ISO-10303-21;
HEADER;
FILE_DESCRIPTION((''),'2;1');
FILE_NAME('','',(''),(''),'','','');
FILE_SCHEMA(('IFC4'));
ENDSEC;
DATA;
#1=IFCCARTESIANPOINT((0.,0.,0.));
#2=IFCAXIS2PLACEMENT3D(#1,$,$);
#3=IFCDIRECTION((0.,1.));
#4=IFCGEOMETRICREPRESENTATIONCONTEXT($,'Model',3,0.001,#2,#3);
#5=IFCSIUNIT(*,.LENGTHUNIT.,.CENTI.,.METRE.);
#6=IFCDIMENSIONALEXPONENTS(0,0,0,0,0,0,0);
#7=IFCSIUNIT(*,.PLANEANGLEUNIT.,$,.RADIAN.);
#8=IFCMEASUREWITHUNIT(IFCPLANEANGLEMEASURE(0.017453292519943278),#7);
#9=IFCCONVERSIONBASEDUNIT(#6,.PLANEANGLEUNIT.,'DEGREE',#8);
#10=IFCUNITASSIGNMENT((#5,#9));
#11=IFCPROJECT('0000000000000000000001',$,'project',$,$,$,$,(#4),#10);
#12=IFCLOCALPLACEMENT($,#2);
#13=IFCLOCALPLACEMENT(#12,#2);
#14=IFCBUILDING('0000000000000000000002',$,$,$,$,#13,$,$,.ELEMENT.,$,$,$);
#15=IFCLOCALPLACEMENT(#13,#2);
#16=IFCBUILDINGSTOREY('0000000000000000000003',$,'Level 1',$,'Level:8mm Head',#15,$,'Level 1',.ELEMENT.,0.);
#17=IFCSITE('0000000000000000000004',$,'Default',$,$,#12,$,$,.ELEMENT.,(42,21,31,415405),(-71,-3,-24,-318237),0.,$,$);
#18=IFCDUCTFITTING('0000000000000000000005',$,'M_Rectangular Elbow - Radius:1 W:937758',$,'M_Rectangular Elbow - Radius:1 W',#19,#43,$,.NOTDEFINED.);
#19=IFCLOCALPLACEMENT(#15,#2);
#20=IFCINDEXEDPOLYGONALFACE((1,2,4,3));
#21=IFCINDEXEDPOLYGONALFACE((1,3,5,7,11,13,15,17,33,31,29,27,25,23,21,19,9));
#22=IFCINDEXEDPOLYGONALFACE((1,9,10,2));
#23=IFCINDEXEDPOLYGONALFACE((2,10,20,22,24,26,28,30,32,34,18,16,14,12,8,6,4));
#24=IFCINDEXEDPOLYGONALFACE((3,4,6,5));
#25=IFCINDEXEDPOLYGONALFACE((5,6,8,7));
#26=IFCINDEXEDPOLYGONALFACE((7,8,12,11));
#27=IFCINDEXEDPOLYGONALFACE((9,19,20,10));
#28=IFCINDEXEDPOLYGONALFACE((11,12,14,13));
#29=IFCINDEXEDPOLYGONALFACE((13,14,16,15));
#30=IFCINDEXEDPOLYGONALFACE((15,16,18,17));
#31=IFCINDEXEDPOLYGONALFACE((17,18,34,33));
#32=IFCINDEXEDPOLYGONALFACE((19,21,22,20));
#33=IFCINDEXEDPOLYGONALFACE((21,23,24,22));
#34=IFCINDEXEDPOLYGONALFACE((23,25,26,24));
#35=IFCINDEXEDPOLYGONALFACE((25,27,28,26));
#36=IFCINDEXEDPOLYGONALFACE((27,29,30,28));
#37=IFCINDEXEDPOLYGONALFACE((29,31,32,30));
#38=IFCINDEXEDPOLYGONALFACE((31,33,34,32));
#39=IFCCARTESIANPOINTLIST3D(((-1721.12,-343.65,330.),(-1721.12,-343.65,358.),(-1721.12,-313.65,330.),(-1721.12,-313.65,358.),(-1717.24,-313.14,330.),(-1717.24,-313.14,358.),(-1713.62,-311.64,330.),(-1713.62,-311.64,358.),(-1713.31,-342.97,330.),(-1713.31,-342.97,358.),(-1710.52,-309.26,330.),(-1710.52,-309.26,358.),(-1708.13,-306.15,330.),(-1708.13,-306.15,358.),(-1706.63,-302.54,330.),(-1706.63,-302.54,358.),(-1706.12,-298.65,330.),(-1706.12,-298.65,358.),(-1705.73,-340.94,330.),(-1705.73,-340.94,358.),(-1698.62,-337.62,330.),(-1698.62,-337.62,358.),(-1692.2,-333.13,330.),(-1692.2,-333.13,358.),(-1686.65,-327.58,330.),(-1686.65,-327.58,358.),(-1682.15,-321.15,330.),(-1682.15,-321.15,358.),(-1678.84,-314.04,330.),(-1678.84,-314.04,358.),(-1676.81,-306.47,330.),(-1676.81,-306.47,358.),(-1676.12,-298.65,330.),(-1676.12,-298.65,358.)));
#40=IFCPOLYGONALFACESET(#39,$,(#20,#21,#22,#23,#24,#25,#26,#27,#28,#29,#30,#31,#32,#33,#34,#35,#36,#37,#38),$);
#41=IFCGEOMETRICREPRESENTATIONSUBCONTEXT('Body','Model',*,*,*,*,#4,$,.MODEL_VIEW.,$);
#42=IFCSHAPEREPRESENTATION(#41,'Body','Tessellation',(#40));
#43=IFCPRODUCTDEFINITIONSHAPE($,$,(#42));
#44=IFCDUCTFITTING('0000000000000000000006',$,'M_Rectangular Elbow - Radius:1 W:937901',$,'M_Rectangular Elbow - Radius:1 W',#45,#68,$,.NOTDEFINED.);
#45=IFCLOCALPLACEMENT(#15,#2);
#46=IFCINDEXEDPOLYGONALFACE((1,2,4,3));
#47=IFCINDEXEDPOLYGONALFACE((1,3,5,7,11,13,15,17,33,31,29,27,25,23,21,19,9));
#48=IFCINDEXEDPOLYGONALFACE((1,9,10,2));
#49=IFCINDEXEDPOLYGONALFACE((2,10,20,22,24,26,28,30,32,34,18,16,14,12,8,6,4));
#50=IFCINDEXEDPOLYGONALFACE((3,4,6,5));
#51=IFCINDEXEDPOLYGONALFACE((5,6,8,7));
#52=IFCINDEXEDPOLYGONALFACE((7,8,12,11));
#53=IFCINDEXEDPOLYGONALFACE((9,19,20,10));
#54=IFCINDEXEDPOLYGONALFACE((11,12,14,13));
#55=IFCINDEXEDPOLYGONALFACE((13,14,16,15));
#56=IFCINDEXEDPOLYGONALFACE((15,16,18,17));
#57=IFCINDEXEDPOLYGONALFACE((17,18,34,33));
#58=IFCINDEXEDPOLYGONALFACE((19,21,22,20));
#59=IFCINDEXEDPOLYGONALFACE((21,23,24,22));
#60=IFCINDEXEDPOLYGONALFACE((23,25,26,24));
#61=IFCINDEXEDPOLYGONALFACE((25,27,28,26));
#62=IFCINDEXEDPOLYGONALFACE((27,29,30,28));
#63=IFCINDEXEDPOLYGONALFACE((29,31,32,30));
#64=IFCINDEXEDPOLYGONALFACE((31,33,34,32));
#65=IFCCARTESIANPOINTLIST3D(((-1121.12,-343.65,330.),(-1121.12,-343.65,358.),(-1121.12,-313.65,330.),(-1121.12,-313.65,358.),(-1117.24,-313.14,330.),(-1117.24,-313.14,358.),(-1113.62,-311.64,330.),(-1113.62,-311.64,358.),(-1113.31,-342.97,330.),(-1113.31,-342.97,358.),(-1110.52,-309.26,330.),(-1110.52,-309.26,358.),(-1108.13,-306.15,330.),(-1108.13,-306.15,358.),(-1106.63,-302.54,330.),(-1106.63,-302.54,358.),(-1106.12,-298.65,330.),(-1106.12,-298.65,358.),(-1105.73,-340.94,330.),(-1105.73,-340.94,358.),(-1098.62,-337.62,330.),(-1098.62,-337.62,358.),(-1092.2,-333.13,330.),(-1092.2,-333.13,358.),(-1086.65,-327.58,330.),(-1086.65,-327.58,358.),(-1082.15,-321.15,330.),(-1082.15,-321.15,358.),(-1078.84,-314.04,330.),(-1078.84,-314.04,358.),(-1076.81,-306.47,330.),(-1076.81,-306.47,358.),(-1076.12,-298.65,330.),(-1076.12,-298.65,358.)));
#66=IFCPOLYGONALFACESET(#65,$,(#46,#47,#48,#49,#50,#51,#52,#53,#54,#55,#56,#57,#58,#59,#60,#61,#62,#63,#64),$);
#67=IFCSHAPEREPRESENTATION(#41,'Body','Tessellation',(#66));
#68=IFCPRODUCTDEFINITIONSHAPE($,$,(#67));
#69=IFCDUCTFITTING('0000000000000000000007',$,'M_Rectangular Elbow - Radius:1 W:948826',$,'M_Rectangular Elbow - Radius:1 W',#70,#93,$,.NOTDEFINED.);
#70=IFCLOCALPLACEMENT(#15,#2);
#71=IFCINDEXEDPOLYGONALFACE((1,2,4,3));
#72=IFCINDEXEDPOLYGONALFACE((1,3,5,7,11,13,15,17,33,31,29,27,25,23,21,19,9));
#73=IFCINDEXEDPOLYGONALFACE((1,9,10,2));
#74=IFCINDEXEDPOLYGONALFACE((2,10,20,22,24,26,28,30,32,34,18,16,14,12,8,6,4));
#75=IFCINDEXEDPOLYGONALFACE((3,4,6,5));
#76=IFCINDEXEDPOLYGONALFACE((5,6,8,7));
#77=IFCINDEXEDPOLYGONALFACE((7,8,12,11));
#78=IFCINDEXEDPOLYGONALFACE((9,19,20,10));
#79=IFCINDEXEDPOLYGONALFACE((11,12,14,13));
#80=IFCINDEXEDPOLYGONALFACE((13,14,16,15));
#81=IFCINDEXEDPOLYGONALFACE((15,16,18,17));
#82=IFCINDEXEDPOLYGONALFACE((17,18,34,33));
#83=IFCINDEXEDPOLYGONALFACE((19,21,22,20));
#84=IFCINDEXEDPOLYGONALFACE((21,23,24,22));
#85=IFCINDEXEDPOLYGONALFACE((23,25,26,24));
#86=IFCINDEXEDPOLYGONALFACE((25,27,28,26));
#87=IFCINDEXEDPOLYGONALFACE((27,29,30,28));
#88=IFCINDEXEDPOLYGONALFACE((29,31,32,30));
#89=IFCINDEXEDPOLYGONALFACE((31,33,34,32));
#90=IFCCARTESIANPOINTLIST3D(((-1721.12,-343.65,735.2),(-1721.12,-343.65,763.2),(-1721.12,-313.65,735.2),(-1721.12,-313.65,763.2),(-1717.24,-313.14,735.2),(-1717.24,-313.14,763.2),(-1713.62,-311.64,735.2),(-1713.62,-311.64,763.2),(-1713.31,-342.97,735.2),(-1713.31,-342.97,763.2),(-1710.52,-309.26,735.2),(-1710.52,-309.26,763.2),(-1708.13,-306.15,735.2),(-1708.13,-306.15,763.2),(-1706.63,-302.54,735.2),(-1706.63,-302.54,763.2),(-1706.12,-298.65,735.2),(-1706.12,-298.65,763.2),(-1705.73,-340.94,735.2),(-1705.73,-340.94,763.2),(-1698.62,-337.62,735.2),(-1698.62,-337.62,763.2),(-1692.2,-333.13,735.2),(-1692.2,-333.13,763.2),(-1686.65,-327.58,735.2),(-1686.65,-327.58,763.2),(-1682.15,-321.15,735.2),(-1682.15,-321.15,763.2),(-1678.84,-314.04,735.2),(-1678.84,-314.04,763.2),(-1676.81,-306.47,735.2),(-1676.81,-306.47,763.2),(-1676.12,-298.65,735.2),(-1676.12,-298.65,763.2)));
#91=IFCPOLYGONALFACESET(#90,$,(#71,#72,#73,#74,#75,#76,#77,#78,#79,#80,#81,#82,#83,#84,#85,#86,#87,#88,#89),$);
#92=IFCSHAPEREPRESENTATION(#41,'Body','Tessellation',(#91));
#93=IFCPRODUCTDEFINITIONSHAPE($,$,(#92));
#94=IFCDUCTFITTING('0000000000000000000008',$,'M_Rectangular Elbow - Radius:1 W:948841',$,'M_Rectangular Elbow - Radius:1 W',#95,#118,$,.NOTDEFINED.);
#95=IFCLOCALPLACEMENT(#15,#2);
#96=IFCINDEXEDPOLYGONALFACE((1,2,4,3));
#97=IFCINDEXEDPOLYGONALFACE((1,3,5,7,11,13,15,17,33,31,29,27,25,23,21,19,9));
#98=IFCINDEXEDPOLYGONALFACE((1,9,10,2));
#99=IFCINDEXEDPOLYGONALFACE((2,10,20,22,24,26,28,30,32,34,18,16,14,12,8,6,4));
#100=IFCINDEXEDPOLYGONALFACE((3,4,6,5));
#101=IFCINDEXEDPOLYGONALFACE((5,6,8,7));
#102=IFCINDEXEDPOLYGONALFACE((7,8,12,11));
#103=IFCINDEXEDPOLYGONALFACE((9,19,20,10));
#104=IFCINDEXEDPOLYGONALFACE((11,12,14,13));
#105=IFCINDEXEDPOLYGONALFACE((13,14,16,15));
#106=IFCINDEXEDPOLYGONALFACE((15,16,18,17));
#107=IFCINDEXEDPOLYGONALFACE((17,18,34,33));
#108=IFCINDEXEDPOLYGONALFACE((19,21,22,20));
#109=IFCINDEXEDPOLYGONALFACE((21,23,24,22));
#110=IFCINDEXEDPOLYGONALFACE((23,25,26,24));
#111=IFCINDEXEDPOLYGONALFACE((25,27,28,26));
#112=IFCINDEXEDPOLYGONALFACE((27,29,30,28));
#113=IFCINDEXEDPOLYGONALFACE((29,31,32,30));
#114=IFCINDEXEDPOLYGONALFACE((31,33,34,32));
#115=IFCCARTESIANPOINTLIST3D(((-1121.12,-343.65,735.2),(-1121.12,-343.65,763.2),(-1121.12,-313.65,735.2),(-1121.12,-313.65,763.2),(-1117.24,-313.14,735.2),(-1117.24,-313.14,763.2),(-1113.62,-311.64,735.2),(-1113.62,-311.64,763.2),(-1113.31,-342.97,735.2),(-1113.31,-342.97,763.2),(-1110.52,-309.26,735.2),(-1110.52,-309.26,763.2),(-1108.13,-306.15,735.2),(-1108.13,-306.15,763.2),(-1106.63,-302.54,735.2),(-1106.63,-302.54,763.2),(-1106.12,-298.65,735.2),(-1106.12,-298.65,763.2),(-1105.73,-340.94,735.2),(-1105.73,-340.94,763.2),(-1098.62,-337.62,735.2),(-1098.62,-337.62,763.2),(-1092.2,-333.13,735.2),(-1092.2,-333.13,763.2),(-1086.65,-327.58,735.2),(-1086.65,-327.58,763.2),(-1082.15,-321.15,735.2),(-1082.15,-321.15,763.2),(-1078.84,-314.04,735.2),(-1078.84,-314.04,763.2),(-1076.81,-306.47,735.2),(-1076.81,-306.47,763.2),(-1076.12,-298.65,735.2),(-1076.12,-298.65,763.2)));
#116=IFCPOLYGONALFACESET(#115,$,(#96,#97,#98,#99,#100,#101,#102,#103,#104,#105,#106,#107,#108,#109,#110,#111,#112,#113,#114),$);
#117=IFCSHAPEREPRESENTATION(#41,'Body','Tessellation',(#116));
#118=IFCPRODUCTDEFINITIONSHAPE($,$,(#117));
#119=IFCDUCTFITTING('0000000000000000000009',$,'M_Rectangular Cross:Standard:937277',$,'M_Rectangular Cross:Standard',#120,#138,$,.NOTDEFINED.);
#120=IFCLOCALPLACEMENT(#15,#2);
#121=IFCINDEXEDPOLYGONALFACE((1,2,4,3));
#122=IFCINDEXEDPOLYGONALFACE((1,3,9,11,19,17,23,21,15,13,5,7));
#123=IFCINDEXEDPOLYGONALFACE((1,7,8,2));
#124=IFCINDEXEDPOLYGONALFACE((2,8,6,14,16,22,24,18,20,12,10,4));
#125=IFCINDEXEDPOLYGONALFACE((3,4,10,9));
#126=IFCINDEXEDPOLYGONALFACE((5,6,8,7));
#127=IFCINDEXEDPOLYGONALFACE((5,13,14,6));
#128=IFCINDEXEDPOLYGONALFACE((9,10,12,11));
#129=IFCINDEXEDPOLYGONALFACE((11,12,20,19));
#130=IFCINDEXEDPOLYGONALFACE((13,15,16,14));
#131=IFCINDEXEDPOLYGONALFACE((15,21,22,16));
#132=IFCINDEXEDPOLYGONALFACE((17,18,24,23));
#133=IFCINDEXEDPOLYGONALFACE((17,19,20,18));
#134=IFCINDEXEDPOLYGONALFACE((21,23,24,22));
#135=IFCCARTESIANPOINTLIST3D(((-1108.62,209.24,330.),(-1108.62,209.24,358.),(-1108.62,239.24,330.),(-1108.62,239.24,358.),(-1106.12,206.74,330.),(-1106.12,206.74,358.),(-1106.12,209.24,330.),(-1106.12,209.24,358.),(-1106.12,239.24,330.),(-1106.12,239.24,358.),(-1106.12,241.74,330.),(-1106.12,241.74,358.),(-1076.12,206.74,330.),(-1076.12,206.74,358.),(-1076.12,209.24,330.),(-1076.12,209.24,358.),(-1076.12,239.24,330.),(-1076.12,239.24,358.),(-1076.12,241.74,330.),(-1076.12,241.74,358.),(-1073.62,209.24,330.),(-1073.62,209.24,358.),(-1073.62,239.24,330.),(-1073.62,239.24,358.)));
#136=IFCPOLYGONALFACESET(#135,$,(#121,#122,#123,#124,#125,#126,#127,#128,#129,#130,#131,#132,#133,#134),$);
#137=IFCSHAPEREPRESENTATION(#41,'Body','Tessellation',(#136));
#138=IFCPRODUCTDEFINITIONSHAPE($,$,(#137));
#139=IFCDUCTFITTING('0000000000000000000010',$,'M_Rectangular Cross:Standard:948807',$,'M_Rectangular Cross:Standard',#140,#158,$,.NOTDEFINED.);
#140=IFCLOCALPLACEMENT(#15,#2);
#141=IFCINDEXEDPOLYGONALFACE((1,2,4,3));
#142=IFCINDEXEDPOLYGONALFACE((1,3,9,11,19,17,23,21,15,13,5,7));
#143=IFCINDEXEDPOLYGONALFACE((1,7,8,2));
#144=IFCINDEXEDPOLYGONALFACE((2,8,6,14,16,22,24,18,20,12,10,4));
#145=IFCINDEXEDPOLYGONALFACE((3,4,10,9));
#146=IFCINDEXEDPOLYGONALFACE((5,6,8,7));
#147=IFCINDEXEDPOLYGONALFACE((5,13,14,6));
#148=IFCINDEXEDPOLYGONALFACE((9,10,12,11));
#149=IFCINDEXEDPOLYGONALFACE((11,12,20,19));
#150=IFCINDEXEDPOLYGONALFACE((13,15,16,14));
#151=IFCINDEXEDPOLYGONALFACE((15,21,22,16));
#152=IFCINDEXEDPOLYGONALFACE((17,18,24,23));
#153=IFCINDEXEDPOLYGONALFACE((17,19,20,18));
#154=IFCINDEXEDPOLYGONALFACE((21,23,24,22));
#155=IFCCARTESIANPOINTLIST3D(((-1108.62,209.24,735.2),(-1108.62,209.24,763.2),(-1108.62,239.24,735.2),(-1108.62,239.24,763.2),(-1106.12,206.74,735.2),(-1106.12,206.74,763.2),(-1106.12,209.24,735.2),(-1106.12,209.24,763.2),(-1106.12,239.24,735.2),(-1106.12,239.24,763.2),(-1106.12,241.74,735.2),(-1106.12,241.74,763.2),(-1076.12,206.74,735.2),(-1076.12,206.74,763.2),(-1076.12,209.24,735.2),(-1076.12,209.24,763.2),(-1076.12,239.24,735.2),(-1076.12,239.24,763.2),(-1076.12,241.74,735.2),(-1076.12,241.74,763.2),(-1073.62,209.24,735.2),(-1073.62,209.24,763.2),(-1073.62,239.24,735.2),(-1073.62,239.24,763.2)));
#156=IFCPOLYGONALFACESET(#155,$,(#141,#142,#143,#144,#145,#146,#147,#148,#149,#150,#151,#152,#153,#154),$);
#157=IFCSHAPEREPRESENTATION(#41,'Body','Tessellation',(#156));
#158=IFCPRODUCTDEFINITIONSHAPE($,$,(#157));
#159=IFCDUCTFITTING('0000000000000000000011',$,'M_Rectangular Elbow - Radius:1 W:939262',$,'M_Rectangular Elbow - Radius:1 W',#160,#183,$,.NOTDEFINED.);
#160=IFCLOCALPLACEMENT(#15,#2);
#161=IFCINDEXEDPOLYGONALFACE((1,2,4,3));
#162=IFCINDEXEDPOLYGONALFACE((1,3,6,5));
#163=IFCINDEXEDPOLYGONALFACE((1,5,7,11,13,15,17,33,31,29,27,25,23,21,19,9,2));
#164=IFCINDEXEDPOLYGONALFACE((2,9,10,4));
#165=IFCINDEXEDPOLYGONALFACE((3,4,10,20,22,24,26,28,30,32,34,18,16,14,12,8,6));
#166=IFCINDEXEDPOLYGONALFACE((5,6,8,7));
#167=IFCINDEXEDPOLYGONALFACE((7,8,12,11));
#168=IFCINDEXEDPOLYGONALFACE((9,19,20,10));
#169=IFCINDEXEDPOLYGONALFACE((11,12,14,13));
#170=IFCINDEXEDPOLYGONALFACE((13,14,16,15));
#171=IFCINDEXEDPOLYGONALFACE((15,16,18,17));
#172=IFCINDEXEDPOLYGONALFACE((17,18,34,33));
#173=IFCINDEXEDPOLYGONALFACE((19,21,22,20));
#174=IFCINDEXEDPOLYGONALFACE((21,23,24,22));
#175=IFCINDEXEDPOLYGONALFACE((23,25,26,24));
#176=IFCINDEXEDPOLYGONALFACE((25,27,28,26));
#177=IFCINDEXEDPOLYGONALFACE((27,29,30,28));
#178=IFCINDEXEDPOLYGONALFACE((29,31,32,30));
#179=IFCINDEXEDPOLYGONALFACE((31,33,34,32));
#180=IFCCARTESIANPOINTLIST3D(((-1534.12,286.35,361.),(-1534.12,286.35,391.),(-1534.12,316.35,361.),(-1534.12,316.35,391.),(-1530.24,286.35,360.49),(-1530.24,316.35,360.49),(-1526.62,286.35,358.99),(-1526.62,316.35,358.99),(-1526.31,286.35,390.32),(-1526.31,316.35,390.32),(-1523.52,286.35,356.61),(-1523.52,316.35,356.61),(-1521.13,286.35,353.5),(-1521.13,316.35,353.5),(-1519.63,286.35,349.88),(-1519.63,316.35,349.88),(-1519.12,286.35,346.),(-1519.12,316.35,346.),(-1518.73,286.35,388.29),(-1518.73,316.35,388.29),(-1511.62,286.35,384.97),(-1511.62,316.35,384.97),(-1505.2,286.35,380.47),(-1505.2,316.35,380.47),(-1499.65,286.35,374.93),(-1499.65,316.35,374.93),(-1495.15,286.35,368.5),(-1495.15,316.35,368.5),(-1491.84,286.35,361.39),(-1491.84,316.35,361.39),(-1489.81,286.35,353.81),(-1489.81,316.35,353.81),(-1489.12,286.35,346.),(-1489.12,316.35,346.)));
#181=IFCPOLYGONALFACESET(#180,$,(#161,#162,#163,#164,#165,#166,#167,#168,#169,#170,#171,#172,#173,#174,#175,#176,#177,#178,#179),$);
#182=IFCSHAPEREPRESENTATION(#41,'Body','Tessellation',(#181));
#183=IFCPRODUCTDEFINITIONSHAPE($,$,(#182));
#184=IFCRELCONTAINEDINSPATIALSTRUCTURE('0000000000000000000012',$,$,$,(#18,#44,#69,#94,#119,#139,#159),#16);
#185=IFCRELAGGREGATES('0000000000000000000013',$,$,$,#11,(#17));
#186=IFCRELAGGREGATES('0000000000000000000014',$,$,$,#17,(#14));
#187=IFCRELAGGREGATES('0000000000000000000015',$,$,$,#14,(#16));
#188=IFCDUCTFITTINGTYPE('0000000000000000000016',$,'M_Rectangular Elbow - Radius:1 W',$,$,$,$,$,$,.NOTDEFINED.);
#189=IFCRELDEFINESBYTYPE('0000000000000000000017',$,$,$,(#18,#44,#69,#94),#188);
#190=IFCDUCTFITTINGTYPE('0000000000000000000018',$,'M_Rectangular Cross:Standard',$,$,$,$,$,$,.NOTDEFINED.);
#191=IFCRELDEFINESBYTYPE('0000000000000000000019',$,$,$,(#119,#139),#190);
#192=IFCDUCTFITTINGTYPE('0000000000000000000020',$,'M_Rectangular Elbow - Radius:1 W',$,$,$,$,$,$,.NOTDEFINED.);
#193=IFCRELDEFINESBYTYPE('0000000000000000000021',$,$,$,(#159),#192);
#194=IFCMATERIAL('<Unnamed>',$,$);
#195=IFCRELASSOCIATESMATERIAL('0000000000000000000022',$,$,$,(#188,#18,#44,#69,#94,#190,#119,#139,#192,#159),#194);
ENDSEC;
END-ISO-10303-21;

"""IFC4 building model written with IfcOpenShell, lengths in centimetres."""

from ifc_helpers import new_model, entity, si_unit, converted_unit, direction, frame, origin, place, context, subcontext, project, spatial, line, arc, indexed_curve, outline, extrude, source, transform, mapped, material, type_object, type_shapes, element, save


model = new_model("IFC4")

# Units and contexts
model_context = context("Model", 3, precision=0.001, world=origin(), true_north=direction((0.0, 1.0)))
body_context = subcontext(model_context, "Body", "Model", "MODEL_VIEW")
ifc_project = project(units=[si_unit("LENGTHUNIT", "METRE", prefix="CENTI"), converted_unit("PLANEANGLEUNIT", "DEGREE", entity("IfcPlaneAngleMeasure", 0.017453292519943278), si_unit("PLANEANGLEUNIT", "RADIAN"), dimensions=[0, 0, 0, 0, 0, 0, 0])], contexts=[model_context])

# Site, building, storey
site_placement = place(None, origin())
site = spatial("IfcSite", under=ifc_project, at=site_placement, Name="Default", CompositionType="ELEMENT", RefLatitude=(42, 21, 31, 415405), RefLongitude=(-71, -3, -24, -318237), RefElevation=0.0)
building_placement = place(site_placement, origin())
building = spatial("IfcBuilding", under=site, at=building_placement, CompositionType="ELEMENT")
storey_placement = place(building_placement, origin())
storey = spatial("IfcBuildingStorey", under=building, at=storey_placement, Name="Level 1", ObjectType="Level:8mm Head", LongName="Level 1", CompositionType="ELEMENT", Elevation=0.0)

# Duct fittings
ifc_material = material(Name="<Unnamed>")
duct_fitting_type_1 = type_object("IfcDuctFittingType", Name="M_Rectangular Elbow - Radius:1 W", PredefinedType="NOTDEFINED", material=ifc_material)
shared_shape_1 = source(origin(), body_context, "Body", "SweptSolid", [
    extrude(outline(indexed_curve([(-30.0, -15.0), (0.0, -15.0), (4.39, -4.39), (15.0, 0.0), (15.0, 30.0), (-16.82, 16.82)], segments=[line(1, 2), arc(2, 3, 4), line(4, 5), arc(5, 6, 1)], self_intersect=False)), frame((-15.0, 15.0, -14.0), z_axis=(0.0, 0.0, 1.0), x_axis=(-1.0, 0.0, 0.0)), (0.0, 0.0, 1.0), 28.0),
])
type_shapes(duct_fitting_type_1, [shared_shape_1])
for number, where, name in (
    (1, (-1691.12, -328.65, 344.0), "M_Rectangular Elbow - Radius:1 W:937758"),
    (2, (-1091.12, -328.65, 344.0), "M_Rectangular Elbow - Radius:1 W:937901"),
    (3, (-1691.12, -328.65, 749.2), "M_Rectangular Elbow - Radius:1 W:948826"),
    (4, (-1091.12, -328.65, 749.2), "M_Rectangular Elbow - Radius:1 W:948841"),
):
    element("IfcDuctFitting", number, at=place(storey_placement, frame(where)), inside=storey, type_object=duct_fitting_type_1, material=ifc_material, Name=name, ObjectType="M_Rectangular Elbow - Radius:1 W", PredefinedType="NOTDEFINED", context=body_context, shape_type="MappedRepresentation", body=[
        mapped(shared_shape_1, transform((0.0, 0.0, 0.0), scale=1.0)),
    ])
duct_fitting_type_2 = type_object("IfcDuctFittingType", Name="M_Rectangular Cross:Standard", PredefinedType="NOTDEFINED", material=ifc_material)
shared_shape_2 = source(origin(), body_context, "Body", "SweptSolid", [
    extrude(outline(indexed_curve([(-17.5, 15.0), (-17.5, -15.0), (-15.0, -15.0), (-15.0, -17.5), (15.0, -17.5), (15.0, -15.0), (17.5, -15.0), (17.5, 15.0), (15.0, 15.0), (15.0, 17.5), (-15.0, 17.5), (-15.0, 15.0), (-17.5, 15.0)], self_intersect=False)), frame((0.0, 0.0, -14.0), z_axis=(0.0, 0.0, -1.0), x_axis=(0.0, 1.0, 0.0)), (0.0, 0.0, -1.0), 28.0),
])
type_shapes(duct_fitting_type_2, [shared_shape_2])
for number, where, name in (
    (5, (-1091.12, 224.24, 344.0), "M_Rectangular Cross:Standard:937277"),
    (6, (-1091.12, 224.24, 749.2), "M_Rectangular Cross:Standard:948807"),
):
    element("IfcDuctFitting", number, at=place(storey_placement, frame(where)), inside=storey, type_object=duct_fitting_type_2, material=ifc_material, Name=name, ObjectType="M_Rectangular Cross:Standard", PredefinedType="NOTDEFINED", context=body_context, shape_type="MappedRepresentation", body=[
        mapped(shared_shape_2, transform((0.0, 0.0, 0.0), scale=1.0)),
    ])
duct_fitting_type_3 = type_object("IfcDuctFittingType", Name="M_Rectangular Elbow - Radius:1 W", PredefinedType="NOTDEFINED", material=ifc_material)
shared_shape_3 = source(origin(), body_context, "Body", "SweptSolid", [
    extrude(outline(indexed_curve([(-30.0, -15.0), (0.0, -15.0), (4.39, -4.39), (15.0, 0.0), (15.0, 30.0), (-16.82, 16.82)], segments=[line(1, 2), arc(2, 3, 4), line(4, 5), arc(5, 6, 1)], self_intersect=False)), frame((-15.0, 15.0, -15.0), z_axis=(0.0, 0.0, 1.0), x_axis=(-1.0, 0.0, 0.0)), (0.0, 0.0, 1.0), 30.0),
])
type_shapes(duct_fitting_type_3, [shared_shape_3])
for number, where, z_axis, x_axis, name in (
    (7, (-1504.12, 301.35, 376.0), (0.0, -1.0, 0.0), (0.0, 0.0, 1.0), "M_Rectangular Elbow - Radius:1 W:939262"),
):
    element("IfcDuctFitting", number, at=place(storey_placement, frame(where, z_axis=z_axis, x_axis=x_axis)), inside=storey, type_object=duct_fitting_type_3, material=ifc_material, Name=name, ObjectType="M_Rectangular Elbow - Radius:1 W", PredefinedType="NOTDEFINED", context=body_context, shape_type="MappedRepresentation", body=[
        mapped(shared_shape_3, transform((0.0, 0.0, 0.0), scale=1.0)),
    ])

save(model, "model.ifc")
